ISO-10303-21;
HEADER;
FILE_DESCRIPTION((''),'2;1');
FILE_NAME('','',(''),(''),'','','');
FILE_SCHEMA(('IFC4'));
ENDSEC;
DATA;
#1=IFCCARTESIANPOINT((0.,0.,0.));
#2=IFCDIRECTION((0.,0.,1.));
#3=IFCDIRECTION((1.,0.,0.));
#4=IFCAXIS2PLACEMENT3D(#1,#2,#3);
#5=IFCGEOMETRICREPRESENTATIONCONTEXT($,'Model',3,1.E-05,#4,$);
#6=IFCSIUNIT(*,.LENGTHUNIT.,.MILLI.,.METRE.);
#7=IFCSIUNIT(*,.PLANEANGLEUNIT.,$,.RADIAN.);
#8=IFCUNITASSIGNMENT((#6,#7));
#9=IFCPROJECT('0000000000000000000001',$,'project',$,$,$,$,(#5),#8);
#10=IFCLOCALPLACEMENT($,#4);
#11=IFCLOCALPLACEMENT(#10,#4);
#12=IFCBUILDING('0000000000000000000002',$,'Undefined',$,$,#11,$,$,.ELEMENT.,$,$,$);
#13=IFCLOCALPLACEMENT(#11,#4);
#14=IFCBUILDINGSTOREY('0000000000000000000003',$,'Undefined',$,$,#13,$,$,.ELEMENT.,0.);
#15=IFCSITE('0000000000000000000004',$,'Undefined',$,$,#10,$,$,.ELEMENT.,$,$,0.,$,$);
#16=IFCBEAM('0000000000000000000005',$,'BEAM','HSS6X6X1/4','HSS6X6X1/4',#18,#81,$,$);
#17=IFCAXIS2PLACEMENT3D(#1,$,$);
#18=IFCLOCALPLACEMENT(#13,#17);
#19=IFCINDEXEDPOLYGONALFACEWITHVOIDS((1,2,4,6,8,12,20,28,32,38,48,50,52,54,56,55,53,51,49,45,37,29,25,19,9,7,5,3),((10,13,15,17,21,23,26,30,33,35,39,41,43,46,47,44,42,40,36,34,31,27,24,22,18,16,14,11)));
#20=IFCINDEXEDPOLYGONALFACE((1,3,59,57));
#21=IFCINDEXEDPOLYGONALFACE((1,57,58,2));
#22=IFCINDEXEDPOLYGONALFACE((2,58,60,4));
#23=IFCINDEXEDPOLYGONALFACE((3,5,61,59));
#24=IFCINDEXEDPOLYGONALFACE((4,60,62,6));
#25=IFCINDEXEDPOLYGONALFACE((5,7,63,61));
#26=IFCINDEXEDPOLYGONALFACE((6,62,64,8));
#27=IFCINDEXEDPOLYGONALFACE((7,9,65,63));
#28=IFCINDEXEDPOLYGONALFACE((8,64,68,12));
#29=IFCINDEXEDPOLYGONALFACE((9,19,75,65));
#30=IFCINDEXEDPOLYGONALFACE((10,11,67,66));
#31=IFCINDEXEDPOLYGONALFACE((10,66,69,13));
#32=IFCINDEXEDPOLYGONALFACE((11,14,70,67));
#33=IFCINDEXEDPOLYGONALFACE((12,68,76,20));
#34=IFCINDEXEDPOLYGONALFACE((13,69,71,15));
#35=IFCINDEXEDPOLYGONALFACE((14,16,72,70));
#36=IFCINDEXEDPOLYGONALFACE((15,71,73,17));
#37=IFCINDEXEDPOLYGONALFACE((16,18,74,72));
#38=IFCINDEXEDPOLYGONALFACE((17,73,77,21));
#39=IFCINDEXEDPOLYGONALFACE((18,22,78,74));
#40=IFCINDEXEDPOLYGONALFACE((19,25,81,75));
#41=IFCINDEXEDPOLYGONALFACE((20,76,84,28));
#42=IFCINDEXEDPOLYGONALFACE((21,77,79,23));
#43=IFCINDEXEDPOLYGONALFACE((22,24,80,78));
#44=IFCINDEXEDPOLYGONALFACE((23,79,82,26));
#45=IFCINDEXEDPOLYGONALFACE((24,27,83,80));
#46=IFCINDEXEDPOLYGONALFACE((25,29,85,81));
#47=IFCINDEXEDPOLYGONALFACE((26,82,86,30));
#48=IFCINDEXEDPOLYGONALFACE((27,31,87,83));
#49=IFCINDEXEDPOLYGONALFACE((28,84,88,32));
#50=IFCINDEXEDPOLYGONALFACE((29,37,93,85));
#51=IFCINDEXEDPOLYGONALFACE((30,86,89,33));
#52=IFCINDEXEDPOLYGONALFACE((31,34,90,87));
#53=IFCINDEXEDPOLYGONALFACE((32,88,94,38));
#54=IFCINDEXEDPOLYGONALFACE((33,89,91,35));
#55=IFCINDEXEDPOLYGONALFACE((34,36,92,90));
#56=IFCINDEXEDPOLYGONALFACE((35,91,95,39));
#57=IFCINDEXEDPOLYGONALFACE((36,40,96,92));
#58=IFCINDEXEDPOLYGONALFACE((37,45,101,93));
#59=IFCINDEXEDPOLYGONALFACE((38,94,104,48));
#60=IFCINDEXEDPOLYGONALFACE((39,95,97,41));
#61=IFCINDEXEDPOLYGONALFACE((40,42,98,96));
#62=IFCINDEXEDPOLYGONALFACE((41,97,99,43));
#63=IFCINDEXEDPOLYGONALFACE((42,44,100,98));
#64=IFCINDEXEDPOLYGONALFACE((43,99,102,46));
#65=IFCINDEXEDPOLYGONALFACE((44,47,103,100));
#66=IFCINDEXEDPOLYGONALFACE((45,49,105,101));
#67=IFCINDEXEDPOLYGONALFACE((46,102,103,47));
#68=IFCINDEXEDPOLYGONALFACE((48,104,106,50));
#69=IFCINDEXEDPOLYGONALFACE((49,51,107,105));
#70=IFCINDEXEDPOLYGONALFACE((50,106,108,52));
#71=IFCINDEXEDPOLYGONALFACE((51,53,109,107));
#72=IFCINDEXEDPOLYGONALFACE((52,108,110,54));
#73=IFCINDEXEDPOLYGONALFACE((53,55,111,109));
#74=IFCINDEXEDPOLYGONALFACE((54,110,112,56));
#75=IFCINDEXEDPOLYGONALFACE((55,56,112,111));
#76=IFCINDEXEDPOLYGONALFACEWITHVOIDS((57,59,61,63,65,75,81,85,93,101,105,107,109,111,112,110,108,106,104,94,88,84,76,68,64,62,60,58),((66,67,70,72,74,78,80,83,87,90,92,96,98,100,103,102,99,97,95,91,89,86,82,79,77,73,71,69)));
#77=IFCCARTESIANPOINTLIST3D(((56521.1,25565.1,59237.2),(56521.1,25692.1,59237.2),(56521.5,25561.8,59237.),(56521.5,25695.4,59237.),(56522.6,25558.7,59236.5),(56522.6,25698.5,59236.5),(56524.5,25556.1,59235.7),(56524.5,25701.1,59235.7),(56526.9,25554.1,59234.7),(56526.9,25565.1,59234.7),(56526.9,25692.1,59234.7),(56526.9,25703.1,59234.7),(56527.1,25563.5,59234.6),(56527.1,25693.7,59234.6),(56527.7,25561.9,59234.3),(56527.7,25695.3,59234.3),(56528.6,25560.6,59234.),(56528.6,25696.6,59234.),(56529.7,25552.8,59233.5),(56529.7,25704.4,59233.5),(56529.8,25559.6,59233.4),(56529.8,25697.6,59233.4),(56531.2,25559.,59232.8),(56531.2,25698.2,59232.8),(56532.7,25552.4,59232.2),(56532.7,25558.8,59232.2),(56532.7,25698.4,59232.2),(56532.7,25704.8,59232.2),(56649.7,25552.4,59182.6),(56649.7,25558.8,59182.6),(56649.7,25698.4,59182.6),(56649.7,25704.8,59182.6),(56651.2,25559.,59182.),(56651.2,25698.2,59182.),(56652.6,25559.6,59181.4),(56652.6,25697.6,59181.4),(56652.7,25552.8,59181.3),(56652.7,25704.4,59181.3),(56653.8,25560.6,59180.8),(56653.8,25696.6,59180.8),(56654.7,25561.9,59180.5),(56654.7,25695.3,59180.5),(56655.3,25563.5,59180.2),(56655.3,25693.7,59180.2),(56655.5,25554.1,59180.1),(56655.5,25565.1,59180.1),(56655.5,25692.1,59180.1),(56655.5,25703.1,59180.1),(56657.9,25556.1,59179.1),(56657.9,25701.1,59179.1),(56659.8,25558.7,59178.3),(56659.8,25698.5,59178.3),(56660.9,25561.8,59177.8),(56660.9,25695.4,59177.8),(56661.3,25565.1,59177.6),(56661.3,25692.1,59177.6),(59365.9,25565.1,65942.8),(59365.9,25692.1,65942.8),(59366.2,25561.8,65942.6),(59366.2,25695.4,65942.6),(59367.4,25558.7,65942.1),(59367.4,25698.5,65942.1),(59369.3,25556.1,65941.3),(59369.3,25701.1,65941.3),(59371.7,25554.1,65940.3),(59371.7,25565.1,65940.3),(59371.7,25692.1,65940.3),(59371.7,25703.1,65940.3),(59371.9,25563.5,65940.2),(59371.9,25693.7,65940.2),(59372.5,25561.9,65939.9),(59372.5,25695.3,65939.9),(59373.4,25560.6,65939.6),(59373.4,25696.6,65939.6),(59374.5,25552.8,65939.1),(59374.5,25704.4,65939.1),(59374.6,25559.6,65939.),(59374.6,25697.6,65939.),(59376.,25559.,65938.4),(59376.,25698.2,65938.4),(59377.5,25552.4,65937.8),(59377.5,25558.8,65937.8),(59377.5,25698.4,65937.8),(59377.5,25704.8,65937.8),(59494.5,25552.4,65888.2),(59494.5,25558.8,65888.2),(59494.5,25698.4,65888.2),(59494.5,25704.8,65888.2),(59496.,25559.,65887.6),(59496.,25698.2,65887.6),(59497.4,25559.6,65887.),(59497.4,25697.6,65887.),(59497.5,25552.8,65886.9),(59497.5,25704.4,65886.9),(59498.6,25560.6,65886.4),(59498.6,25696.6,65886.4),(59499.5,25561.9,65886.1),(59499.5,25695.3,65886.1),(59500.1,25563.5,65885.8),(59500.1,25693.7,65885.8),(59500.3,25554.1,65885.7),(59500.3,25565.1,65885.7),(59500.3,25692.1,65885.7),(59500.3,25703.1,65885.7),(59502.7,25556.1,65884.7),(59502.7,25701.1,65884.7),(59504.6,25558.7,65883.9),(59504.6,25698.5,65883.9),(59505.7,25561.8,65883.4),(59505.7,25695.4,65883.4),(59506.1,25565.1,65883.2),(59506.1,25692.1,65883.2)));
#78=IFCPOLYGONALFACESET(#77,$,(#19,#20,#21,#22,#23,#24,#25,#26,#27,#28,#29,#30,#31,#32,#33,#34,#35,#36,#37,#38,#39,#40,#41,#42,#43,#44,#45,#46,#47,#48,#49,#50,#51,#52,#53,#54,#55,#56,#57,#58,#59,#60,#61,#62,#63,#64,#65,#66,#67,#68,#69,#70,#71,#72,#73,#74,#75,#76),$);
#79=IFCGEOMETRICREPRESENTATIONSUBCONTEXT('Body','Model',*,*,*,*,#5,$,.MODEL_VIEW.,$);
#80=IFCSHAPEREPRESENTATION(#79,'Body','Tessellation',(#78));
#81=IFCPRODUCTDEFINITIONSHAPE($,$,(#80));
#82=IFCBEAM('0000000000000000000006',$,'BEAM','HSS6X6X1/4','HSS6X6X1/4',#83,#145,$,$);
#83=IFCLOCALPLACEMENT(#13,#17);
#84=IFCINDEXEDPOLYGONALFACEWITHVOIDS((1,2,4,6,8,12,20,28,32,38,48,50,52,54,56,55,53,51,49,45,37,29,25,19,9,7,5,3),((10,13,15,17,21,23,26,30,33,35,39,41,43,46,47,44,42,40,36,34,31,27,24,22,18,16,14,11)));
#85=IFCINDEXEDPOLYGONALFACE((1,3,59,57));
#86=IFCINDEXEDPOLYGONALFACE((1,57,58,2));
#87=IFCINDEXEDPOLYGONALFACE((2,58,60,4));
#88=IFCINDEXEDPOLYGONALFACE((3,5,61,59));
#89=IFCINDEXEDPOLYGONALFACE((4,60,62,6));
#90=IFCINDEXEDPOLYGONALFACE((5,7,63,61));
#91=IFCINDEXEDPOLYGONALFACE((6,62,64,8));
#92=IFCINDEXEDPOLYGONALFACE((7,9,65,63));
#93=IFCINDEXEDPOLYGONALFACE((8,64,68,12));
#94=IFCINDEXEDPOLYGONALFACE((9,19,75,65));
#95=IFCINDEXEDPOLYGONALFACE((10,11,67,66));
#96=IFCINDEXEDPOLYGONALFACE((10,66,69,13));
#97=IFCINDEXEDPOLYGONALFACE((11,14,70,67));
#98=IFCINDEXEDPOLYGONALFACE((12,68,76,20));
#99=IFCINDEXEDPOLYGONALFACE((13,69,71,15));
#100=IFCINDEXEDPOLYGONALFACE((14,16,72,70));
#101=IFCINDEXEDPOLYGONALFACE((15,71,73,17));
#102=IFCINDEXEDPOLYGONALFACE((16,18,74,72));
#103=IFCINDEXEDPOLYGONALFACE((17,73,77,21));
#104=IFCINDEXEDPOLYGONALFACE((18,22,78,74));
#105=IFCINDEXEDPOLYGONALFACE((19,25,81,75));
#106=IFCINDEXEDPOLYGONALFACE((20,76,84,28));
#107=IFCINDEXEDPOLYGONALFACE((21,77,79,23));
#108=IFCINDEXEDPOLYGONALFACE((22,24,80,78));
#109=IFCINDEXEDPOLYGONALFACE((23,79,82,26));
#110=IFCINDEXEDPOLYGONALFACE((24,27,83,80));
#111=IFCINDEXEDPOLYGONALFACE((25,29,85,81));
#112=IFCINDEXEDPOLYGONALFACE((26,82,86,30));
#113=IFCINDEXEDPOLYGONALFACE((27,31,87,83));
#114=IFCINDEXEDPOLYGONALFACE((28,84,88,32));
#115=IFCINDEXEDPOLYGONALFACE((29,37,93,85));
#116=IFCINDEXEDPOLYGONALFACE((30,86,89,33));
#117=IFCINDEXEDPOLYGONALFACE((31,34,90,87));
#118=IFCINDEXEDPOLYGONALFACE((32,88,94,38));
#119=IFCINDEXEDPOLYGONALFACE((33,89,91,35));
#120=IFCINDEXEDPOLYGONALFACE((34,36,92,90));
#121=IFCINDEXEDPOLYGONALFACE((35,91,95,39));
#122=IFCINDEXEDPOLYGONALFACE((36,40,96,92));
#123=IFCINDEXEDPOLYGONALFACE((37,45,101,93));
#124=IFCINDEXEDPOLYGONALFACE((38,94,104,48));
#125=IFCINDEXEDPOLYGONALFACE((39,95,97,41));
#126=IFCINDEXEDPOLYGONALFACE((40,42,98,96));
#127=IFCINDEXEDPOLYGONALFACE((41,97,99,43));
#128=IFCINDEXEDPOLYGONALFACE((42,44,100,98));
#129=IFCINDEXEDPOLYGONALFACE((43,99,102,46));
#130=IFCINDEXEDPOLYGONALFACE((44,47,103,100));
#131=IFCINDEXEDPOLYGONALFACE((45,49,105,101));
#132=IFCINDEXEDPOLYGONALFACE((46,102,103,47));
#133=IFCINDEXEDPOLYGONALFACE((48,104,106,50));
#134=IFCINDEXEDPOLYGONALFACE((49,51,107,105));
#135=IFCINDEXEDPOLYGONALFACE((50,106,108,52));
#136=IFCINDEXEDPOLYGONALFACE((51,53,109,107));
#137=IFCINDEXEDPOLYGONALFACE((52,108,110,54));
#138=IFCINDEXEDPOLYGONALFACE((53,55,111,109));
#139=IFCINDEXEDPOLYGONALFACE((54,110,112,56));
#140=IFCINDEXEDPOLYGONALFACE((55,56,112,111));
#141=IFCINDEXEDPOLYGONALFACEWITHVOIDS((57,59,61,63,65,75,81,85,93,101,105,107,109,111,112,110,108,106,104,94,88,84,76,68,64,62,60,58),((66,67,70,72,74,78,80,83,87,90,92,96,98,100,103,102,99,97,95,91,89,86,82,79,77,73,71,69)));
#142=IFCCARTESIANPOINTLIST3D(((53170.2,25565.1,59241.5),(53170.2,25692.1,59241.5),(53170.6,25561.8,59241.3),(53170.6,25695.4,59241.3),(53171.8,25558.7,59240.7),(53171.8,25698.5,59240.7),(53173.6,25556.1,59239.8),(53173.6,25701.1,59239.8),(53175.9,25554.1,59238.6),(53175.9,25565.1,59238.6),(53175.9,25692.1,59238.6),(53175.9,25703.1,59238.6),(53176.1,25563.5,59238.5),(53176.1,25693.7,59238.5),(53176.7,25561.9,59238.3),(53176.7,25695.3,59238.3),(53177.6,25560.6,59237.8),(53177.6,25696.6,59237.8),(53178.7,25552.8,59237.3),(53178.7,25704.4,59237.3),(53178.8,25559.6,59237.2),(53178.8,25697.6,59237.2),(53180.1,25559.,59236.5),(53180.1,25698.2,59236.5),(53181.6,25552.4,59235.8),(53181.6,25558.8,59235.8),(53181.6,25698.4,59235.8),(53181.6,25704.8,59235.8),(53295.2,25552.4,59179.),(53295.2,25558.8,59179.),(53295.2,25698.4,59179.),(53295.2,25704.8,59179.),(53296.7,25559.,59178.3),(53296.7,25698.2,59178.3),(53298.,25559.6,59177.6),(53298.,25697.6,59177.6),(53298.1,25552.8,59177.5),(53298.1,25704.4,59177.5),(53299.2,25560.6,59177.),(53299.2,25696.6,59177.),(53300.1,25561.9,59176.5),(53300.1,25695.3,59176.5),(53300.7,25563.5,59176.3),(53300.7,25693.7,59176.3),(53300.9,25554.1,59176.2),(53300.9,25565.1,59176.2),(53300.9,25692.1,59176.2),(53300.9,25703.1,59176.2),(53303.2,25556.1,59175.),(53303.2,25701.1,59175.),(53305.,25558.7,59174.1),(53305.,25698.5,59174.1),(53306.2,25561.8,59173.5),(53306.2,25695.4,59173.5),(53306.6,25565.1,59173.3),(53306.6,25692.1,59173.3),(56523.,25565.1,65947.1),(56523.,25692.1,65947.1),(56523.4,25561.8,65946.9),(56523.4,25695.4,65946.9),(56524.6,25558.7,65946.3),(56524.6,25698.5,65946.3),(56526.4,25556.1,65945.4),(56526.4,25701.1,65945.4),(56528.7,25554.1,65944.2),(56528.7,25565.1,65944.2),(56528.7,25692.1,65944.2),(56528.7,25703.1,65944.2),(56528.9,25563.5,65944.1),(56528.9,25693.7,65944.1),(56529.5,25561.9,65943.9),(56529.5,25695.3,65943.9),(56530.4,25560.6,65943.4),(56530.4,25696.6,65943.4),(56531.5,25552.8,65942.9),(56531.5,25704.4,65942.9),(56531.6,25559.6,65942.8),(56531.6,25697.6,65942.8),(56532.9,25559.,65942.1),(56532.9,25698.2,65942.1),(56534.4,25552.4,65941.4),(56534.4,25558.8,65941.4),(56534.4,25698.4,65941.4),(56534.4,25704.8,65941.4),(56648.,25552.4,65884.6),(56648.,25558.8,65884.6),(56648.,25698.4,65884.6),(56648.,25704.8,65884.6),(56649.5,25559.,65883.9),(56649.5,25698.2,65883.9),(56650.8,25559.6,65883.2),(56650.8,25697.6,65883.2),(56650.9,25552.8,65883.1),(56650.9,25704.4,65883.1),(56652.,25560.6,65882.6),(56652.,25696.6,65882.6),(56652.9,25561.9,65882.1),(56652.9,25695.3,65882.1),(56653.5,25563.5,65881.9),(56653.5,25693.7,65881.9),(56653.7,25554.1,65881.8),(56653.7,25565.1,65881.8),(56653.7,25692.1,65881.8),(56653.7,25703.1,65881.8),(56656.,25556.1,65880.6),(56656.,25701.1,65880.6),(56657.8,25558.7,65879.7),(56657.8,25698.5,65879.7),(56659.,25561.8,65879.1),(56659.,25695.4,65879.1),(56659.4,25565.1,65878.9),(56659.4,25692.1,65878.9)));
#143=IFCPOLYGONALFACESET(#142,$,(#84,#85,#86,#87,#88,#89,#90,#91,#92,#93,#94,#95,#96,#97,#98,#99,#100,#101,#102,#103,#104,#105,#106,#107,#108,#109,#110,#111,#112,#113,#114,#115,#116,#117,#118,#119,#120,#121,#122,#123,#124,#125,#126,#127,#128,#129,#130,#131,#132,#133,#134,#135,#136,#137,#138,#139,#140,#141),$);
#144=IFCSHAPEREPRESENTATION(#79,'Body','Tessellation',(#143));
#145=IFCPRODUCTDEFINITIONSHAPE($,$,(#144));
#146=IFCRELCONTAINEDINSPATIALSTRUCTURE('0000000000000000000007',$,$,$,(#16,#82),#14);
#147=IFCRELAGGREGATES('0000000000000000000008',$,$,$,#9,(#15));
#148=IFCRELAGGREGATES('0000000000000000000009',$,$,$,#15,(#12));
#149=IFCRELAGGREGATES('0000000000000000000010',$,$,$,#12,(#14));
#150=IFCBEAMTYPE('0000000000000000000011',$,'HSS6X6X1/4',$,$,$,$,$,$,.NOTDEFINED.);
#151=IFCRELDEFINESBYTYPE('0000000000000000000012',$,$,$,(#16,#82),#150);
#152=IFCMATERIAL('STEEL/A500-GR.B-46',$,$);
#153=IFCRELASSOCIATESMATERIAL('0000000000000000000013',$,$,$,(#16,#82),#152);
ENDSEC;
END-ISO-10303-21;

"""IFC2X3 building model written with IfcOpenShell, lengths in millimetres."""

from ifc_helpers import new_model, si_unit, frame, origin_with_axes, origin_2d_with_axis, place, context, subcontext, project, spatial, hollow_rectangle, extrude, material, type_object, element, save


model = new_model("IFC2X3")

# Units and contexts
model_context = context("Model", 3, precision=1e-05, world=origin_with_axes())
body_context = subcontext(model_context, "Body", "Model", "MODEL_VIEW")
ifc_project = project(units=[si_unit("LENGTHUNIT", "METRE", prefix="MILLI"), si_unit("PLANEANGLEUNIT", "RADIAN")], contexts=[model_context])

# Site, building, storey
site_placement = place(None, origin_with_axes())
site = spatial("IfcSite", under=ifc_project, at=site_placement, Name="Undefined", CompositionType="ELEMENT", RefElevation=0.0)
building_placement = place(site_placement, origin_with_axes())
building = spatial("IfcBuilding", under=site, at=building_placement, Name="Undefined", CompositionType="ELEMENT")
storey_placement = place(building_placement, origin_with_axes())
storey = spatial("IfcBuildingStorey", under=building, at=storey_placement, Name="Undefined", CompositionType="ELEMENT", Elevation=0.0)

# Beams
ifc_material_1 = material(Name="STEEL/A500-GR.B-46")
beam_type_1 = type_object("IfcBeamType", Name="HSS6X6X1/4", PredefinedType="NOTDEFINED")
beam_1_placement = place(storey_placement, frame((56591.2, 25628.6, 59207.4), z_axis=(-0.920582, 0.0, 0.39055), x_axis=(0.39055, 0.0, 0.920582)))
element("IfcBeam", 1, at=beam_1_placement, inside=storey, type_object=beam_type_1, material=ifc_material_1, Name="BEAM", Description="HSS6X6X1/4", ObjectType="HSS6X6X1/4", context=body_context, shape_type="SweptSolid", body=[
    extrude(hollow_rectangle(XDim=152.4, YDim=152.4, WallThickness=6.3, InnerFilletRadius=6.3, OuterFilletRadius=12.7, at=origin_2d_with_axis()), frame((7284.1, 0.0, 0.0), z_axis=(-1.0, 0.0, 0.0), x_axis=(0.0, -1.0, 0.0)), (0.0, 0.0, 1.0), 7284.1),
])
beam_2_placement = place(storey_placement, frame((53238.4, 25628.6, 59207.4), z_axis=(-0.894427, 0.0, 0.447214), x_axis=(0.447214, 0.0, 0.894427)))
element("IfcBeam", 2, at=beam_2_placement, inside=storey, type_object=beam_type_1, material=ifc_material_1, Name="BEAM", Description="HSS6X6X1/4", ObjectType="HSS6X6X1/4", context=body_context, shape_type="SweptSolid", body=[
    extrude(hollow_rectangle(XDim=152.4, YDim=152.4, WallThickness=6.3, InnerFilletRadius=6.3, OuterFilletRadius=12.7, at=origin_2d_with_axis()), frame((7497.1, 0.0, 0.0), z_axis=(-1.0, 0.0, 0.0), x_axis=(0.0, -1.0, 0.0)), (0.0, 0.0, 1.0), 7497.1),
])

save(model, "model.ifc")
